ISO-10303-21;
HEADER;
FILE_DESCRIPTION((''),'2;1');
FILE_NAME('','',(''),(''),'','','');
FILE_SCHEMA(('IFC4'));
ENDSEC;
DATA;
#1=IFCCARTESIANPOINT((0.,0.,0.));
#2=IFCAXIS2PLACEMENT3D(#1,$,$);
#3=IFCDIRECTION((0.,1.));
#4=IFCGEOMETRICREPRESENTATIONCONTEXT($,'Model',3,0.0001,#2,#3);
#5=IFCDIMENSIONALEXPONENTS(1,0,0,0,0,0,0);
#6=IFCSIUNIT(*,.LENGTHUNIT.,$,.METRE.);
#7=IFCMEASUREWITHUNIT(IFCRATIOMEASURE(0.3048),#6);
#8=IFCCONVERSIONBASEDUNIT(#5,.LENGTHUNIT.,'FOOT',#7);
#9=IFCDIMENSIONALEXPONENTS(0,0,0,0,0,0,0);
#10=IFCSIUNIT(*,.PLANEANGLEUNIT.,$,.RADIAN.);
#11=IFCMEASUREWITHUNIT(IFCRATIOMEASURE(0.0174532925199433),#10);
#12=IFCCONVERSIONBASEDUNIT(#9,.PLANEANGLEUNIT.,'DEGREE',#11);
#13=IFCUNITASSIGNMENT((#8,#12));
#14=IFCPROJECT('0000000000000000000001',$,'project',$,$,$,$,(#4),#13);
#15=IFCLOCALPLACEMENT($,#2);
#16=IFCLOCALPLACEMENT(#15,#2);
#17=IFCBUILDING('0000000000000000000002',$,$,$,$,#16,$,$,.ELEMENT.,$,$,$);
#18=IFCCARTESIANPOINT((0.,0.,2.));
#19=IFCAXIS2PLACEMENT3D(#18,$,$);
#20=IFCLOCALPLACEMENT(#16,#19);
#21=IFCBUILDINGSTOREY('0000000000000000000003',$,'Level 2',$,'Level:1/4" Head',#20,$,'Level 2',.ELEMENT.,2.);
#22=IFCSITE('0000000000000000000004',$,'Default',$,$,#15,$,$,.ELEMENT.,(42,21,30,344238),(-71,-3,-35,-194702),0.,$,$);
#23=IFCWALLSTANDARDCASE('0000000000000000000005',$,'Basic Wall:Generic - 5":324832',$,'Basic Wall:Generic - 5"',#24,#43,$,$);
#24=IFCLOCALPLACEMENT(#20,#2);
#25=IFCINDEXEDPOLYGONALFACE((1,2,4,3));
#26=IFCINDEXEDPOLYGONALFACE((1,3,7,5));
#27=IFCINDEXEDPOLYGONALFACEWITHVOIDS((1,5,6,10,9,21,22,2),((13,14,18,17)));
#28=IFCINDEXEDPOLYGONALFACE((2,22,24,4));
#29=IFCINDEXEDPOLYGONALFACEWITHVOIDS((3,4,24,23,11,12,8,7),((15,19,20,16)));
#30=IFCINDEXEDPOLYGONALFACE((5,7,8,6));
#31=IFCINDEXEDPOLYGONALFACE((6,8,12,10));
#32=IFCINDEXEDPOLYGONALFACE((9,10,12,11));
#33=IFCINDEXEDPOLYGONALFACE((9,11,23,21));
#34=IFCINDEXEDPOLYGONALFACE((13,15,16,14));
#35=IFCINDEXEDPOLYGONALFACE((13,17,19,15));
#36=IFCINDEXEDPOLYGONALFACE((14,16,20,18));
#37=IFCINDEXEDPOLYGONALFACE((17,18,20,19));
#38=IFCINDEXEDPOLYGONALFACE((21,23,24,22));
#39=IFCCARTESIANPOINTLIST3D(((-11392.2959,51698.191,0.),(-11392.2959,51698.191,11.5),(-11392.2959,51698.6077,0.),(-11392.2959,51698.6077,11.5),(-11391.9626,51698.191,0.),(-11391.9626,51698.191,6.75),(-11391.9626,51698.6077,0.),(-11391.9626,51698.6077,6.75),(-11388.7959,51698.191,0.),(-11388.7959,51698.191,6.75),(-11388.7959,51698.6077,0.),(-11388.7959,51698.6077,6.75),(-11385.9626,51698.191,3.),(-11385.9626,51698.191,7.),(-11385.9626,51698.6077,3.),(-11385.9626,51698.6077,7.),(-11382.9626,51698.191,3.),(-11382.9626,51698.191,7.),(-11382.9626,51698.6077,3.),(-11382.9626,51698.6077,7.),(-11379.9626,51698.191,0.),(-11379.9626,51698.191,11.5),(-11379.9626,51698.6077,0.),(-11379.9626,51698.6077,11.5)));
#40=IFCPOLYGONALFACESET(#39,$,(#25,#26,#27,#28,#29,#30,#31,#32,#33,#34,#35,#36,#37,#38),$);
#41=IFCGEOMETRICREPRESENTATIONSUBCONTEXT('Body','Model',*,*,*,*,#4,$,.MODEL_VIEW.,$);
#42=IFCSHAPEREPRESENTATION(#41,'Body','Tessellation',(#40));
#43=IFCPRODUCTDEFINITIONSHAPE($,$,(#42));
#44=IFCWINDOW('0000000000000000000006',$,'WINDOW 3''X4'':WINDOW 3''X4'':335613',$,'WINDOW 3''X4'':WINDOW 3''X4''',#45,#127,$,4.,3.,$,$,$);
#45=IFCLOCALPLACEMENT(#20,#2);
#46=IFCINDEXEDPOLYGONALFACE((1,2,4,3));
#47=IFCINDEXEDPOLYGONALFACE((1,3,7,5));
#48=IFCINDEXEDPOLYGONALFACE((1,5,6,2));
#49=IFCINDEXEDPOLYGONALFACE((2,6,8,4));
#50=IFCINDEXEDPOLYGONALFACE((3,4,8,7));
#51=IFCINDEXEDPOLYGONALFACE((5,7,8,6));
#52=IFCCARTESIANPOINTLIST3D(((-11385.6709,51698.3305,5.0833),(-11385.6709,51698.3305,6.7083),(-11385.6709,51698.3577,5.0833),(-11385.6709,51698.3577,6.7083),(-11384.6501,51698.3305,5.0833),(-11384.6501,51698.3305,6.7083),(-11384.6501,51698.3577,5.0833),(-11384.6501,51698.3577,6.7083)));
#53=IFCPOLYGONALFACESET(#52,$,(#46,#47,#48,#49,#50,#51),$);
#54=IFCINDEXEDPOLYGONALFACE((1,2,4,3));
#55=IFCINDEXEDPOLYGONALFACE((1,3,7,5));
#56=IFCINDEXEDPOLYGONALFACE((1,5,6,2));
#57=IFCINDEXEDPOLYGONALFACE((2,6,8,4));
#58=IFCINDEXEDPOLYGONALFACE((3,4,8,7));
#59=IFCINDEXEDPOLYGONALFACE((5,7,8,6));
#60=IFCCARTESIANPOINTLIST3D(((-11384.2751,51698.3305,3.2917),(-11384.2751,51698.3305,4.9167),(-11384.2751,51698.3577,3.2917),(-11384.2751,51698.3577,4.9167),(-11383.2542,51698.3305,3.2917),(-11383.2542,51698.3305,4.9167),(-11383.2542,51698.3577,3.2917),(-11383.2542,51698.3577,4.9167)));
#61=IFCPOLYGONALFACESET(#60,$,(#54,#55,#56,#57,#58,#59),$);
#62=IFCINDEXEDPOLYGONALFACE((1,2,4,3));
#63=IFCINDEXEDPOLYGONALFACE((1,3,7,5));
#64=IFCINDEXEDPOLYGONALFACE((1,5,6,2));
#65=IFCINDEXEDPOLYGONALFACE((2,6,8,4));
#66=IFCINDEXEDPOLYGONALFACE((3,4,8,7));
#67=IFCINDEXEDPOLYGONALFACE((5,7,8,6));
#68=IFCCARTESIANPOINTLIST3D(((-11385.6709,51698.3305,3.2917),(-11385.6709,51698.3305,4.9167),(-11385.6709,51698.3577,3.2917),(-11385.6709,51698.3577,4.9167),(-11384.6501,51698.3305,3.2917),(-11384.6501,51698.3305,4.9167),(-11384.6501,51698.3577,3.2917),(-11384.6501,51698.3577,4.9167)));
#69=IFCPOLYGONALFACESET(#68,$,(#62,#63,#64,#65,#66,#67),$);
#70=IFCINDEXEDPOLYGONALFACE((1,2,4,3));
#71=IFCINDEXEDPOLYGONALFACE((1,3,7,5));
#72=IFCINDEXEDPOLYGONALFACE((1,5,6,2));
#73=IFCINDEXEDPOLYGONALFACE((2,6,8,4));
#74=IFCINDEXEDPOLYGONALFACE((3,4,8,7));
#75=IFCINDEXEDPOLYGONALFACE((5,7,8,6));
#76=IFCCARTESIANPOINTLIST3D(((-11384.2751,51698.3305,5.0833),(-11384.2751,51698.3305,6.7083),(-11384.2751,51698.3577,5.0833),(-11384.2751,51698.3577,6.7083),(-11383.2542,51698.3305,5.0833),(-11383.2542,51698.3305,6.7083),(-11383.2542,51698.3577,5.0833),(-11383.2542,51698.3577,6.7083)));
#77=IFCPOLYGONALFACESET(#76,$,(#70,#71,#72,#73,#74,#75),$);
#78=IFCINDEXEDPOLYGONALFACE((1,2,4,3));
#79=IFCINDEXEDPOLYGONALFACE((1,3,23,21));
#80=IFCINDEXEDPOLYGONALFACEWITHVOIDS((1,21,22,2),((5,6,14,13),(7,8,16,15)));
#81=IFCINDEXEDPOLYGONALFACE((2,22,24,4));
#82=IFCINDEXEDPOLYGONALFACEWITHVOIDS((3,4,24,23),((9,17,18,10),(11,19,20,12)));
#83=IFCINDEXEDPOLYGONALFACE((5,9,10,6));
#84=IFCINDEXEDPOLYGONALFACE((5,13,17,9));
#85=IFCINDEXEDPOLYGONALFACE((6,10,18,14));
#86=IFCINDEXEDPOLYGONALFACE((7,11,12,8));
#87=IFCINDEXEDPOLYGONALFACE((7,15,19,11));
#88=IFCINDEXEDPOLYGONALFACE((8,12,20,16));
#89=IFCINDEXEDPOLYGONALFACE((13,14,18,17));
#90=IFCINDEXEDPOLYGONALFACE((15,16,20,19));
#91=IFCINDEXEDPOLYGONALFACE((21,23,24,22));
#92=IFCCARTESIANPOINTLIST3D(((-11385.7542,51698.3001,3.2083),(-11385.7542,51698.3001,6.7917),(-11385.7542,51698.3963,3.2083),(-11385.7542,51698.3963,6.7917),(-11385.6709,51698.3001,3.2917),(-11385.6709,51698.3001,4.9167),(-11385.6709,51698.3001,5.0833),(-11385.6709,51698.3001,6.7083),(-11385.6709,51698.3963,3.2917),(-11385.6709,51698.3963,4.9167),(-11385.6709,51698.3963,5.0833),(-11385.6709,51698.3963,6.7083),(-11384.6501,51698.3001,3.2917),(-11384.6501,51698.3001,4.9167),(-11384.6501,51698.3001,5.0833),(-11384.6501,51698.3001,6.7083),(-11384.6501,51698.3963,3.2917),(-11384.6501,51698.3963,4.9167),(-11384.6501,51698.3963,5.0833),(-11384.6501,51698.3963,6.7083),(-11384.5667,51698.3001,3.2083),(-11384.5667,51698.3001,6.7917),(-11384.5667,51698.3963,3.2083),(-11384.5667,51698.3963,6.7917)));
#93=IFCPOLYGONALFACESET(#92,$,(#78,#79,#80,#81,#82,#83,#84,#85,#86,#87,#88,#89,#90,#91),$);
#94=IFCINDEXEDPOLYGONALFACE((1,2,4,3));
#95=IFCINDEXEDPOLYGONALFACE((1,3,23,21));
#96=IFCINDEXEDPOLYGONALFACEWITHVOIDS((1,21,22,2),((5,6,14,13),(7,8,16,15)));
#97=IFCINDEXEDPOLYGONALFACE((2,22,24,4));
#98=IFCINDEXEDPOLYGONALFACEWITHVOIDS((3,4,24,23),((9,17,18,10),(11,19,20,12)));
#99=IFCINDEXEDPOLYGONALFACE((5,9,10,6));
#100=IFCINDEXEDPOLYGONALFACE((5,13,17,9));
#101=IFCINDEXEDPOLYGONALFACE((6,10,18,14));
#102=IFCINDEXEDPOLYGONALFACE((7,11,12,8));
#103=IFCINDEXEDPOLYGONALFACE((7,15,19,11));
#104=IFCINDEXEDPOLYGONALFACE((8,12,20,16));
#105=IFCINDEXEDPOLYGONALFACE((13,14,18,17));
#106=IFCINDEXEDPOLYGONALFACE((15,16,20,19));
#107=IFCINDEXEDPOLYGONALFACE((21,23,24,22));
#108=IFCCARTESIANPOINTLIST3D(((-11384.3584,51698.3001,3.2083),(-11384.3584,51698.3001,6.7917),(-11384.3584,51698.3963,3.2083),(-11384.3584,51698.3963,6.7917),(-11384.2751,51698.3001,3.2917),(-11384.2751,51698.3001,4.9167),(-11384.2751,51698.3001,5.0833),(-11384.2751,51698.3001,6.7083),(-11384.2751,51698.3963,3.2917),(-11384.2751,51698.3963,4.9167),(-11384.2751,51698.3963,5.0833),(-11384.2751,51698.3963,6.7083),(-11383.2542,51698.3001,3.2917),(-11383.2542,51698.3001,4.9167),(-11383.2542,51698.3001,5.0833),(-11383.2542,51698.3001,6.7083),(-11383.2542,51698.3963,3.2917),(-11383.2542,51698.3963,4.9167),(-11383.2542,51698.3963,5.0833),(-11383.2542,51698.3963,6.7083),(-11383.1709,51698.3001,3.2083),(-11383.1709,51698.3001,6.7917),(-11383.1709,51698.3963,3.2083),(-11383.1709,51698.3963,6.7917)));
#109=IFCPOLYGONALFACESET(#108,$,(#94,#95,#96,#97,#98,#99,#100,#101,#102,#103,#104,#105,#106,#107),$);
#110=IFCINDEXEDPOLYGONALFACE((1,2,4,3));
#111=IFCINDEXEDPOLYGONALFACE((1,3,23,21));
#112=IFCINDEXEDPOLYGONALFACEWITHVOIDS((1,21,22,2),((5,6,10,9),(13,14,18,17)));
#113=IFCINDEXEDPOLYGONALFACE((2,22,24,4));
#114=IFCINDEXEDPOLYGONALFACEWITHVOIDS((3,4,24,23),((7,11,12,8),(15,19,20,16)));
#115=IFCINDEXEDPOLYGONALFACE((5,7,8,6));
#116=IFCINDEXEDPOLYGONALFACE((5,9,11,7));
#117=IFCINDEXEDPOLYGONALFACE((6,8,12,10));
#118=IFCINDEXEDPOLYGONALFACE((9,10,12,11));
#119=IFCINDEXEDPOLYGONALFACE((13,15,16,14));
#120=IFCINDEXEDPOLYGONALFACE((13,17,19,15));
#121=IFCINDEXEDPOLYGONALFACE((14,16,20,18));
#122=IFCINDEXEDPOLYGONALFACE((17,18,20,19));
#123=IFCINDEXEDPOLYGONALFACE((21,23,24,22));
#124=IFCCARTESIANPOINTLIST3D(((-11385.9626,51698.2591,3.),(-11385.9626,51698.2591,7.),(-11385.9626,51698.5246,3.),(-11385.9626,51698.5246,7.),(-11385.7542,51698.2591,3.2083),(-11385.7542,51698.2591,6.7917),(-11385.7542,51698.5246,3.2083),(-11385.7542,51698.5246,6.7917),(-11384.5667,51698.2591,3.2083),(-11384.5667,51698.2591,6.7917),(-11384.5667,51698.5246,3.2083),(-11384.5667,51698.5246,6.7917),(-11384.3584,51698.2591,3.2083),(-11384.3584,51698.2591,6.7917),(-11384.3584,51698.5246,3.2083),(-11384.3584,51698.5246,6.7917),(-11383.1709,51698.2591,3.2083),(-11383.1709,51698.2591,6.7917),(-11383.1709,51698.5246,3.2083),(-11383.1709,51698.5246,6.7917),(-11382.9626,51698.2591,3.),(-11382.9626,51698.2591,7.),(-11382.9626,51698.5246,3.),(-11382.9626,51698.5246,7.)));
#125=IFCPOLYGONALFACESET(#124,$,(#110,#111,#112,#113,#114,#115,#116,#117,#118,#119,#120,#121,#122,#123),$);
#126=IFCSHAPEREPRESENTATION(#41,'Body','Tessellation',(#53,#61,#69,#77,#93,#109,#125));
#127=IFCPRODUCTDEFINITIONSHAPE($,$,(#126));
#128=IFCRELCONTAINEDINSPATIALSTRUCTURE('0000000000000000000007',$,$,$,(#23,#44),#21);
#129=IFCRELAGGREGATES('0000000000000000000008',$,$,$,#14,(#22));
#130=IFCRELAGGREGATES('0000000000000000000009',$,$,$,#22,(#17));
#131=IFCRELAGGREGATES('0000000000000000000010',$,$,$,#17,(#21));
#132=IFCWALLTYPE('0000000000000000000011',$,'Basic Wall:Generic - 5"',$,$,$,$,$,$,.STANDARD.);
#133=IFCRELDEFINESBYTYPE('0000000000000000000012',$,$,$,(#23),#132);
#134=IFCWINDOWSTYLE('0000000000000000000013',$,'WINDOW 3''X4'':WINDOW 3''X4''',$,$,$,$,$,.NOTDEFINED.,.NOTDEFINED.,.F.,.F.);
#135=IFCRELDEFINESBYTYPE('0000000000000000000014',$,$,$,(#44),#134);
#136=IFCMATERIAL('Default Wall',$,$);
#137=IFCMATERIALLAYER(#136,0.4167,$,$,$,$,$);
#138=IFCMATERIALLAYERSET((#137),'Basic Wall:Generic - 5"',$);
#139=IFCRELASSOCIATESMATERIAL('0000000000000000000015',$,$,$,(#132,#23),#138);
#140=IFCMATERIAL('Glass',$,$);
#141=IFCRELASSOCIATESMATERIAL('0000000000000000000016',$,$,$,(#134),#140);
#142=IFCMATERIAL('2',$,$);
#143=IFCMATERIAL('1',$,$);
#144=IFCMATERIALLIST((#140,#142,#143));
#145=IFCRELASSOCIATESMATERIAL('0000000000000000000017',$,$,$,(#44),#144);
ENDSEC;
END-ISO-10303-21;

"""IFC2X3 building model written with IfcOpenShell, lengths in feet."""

from ifc_helpers import new_model, entity, si_unit, converted_unit, direction, frame, frame_2d, origin, origin_2d_with_axis, place, context, subcontext, project, spatial, polyline, rectangle, outline, extrude, source, transform, mapped, material, material_list, layer, layer_set, layer_usage, type_object, type_shapes, element, fill, save


model = new_model("IFC2X3")

# Units and contexts
model_context = context("Model", 3, precision=0.0001, world=origin(), true_north=direction((0.0, 1.0)))
body_context = subcontext(model_context, "Body", "Model", "MODEL_VIEW")
ifc_project = project(units=[converted_unit("LENGTHUNIT", "FOOT", entity("IfcRatioMeasure", 0.3048), si_unit("LENGTHUNIT", "METRE"), dimensions=[1, 0, 0, 0, 0, 0, 0]), converted_unit("PLANEANGLEUNIT", "DEGREE", entity("IfcRatioMeasure", 0.0174532925199433), si_unit("PLANEANGLEUNIT", "RADIAN"), dimensions=[0, 0, 0, 0, 0, 0, 0])], contexts=[model_context])

# Site, building, storey
site_placement = place(None, origin())
site = spatial("IfcSite", under=ifc_project, at=site_placement, Name="Default", CompositionType="ELEMENT", RefLatitude=(42, 21, 30, 344238), RefLongitude=(-71, -3, -35, -194702), RefElevation=0.0)
building_placement = place(site_placement, origin())
building = spatial("IfcBuilding", under=site, at=building_placement, CompositionType="ELEMENT")
storey_placement = place(building_placement, frame((0.0, 0.0, 2.0)))
storey = spatial("IfcBuildingStorey", under=building, at=storey_placement, Name="Level 2", ObjectType="Level:1/4\" Head", LongName="Level 2", CompositionType="ELEMENT", Elevation=2.0)

# Shared definitions
ifc_material_1 = material(Name="Default Wall")
ifc_material_2 = material(Name="Glass")
ifc_material_3 = material(Name="2")
ifc_material_4 = material(Name="1")
ifc_layer_1 = layer(ifc_material_1, 0.4167)
ifc_layer_set_1 = layer_set([ifc_layer_1], Name="Basic Wall:Generic - 5\"")
wall_type_1 = type_object("IfcWallType", Name="Basic Wall:Generic - 5\"", PredefinedType="STANDARD", material=ifc_layer_set_1)

# Wall, openings, window
window_style_1 = type_object("IfcWindowStyle", Name="WINDOW 3'X4':WINDOW 3'X4'", ConstructionType="NOTDEFINED", OperationType="NOTDEFINED", ParameterTakesPrecedence=False, Sizeable=False, material=ifc_material_2)
shared_shape_1 = source(origin(), body_context, "Body", "SweptSolid", [
    extrude(rectangle(XDim=0.0272, YDim=1.0208, at=origin_2d_with_axis()), frame((2.1979, 0.2636, 2.0833), z_axis=(0.0, 0.0, 1.0), x_axis=(0.0, 1.0, 0.0)), (0.0, 0.0, 1.0), 1.625),
    extrude(rectangle(XDim=0.0272, YDim=1.0208, at=origin_2d_with_axis()), frame((0.8021, 0.2636, 0.2917), z_axis=(0.0, 0.0, 1.0), x_axis=(0.0, 1.0, 0.0)), (0.0, 0.0, 1.0), 1.625),
    extrude(rectangle(XDim=0.0272, YDim=1.0208, at=origin_2d_with_axis()), frame((2.1979, 0.2636, 0.2917), z_axis=(0.0, 0.0, 1.0), x_axis=(0.0, 1.0, 0.0)), (0.0, 0.0, 1.0), 1.625),
    extrude(rectangle(XDim=0.0272, YDim=1.0208, at=origin_2d_with_axis()), frame((0.8021, 0.2636, 2.0833), z_axis=(0.0, 0.0, 1.0), x_axis=(0.0, 1.0, 0.0)), (0.0, 0.0, 1.0), 1.625),
    extrude(outline(polyline([(-0.5938, -1.7917), (0.5938, -1.7917), (0.5938, 1.7917), (-0.5938, 1.7917), (-0.5938, -1.7917)]), holes=[polyline([(-0.5104, -0.0833), (0.5104, -0.0833), (0.5104, -1.7083), (-0.5104, -1.7083), (-0.5104, -0.0833)]), polyline([(-0.5104, 1.7083), (0.5104, 1.7083), (0.5104, 0.0833), (-0.5104, 0.0833), (-0.5104, 1.7083)])]), frame((2.1979, 0.2114, 2.0), z_axis=(0.0, 1.0, 0.0), x_axis=(-1.0, 0.0, 0.0)), (0.0, 0.0, 1.0), 0.0962),
    extrude(outline(polyline([(-1.7917, -0.5937), (1.7917, -0.5937), (1.7917, 0.5937), (-1.7917, 0.5937), (-1.7917, -0.5937)]), holes=[polyline([(0.0833, -0.5104), (0.0833, 0.5104), (1.7083, 0.5104), (1.7083, -0.5104), (0.0833, -0.5104)]), polyline([(-1.7083, -0.5104), (-1.7083, 0.5104), (-0.0833, 0.5104), (-0.0833, -0.5104), (-1.7083, -0.5104)])]), frame((0.8021, 0.2114, 2.0), z_axis=(0.0, 1.0, 0.0), x_axis=(0.0, 0.0, -1.0)), (0.0, 0.0, 1.0), 0.0962),
    extrude(outline(polyline([(-1.5, -2.0), (1.5, -2.0), (1.5, 2.0), (-1.5, 2.0), (-1.5, -2.0)]), holes=[polyline([(-0.1042, 1.7917), (-0.1042, -1.7917), (-1.2917, -1.7917), (-1.2917, 1.7917), (-0.1042, 1.7917)]), polyline([(0.1042, -1.7917), (0.1042, 1.7917), (1.2917, 1.7917), (1.2917, -1.7917), (0.1042, -1.7917)])]), frame((1.5, 0.0831, 2.0), z_axis=(0.0, 1.0, 0.0), x_axis=(1.0, 0.0, 0.0)), (0.0, 0.0, 1.0), 0.2655),
])
type_shapes(window_style_1, [shared_shape_1])
ifc_layer_usage_1 = layer_usage(ifc_layer_set_1, "AXIS2", "NEGATIVE", 0.2083)
wall_1_placement = place(storey_placement, frame((-11379.9626, 51698.3993, 0.0), z_axis=(0.0, 0.0, 1.0), x_axis=(-1.0, 0.0, 0.0)))
wall_1 = element("IfcWallStandardCase", 1, at=wall_1_placement, inside=storey, type_object=wall_type_1, material=ifc_layer_usage_1, Name="Basic Wall:Generic - 5\":324832", ObjectType="Basic Wall:Generic - 5\"", context=body_context, shape_type="SweptSolid", body=[
    extrude(rectangle(XDim=12.3333, YDim=0.4167, at=frame_2d((6.1667, 0.0), x_axis=(-1.0, 0.0))), origin(), (0.0, 0.0, 1.0), 11.5),
])
opening_1_placement = place(wall_1_placement, frame((12.0, 0.2083, 0.0)))
element("IfcOpeningElement", 2, at=opening_1_placement, cuts=wall_1, ObjectType="Opening", context=body_context, shape_type="SweptSolid", body=[
    extrude(rectangle(XDim=6.75, YDim=3.1667, at=frame_2d((3.375, 1.5833), x_axis=(1.0, 0.0))), frame((0.0, 0.0, 0.0), z_axis=(0.0, -1.0, 0.0), x_axis=(0.0, 0.0, 1.0)), (0.0, 0.0, 1.0), 0.4167),
])
opening_2_placement = place(wall_1_placement, frame((3.0, -0.2083, 3.0)))
opening_2 = element("IfcOpeningElement", 3, at=opening_2_placement, cuts=wall_1, ObjectType="Opening", context=body_context, shape_type="SweptSolid", body=[
    extrude(rectangle(XDim=4.0, YDim=3.0, at=frame_2d((2.0, 1.5), x_axis=(-1.0, 0.0))), frame((0.0, 0.0, 0.0), z_axis=(0.0, 1.0, 0.0), x_axis=(0.0, 0.0, 1.0)), (0.0, 0.0, 1.0), 0.4167),
])
ifc_material_list_1 = material_list([ifc_material_2, ifc_material_3, ifc_material_4])
window_1_placement = place(opening_2_placement, origin())
window_1 = element("IfcWindow", 4, at=window_1_placement, inside=storey, type_object=window_style_1, material=ifc_material_list_1, Name="WINDOW 3'X4':WINDOW 3'X4':335613", ObjectType="WINDOW 3'X4':WINDOW 3'X4'", OverallHeight=4.0, OverallWidth=3.0, context=body_context, shape_type="MappedRepresentation", body=[
    mapped(shared_shape_1, transform((0.0, 0.0, 0.0), scale=1.0)),
])
fill(opening_2, window_1)

save(model, "model.ifc")
